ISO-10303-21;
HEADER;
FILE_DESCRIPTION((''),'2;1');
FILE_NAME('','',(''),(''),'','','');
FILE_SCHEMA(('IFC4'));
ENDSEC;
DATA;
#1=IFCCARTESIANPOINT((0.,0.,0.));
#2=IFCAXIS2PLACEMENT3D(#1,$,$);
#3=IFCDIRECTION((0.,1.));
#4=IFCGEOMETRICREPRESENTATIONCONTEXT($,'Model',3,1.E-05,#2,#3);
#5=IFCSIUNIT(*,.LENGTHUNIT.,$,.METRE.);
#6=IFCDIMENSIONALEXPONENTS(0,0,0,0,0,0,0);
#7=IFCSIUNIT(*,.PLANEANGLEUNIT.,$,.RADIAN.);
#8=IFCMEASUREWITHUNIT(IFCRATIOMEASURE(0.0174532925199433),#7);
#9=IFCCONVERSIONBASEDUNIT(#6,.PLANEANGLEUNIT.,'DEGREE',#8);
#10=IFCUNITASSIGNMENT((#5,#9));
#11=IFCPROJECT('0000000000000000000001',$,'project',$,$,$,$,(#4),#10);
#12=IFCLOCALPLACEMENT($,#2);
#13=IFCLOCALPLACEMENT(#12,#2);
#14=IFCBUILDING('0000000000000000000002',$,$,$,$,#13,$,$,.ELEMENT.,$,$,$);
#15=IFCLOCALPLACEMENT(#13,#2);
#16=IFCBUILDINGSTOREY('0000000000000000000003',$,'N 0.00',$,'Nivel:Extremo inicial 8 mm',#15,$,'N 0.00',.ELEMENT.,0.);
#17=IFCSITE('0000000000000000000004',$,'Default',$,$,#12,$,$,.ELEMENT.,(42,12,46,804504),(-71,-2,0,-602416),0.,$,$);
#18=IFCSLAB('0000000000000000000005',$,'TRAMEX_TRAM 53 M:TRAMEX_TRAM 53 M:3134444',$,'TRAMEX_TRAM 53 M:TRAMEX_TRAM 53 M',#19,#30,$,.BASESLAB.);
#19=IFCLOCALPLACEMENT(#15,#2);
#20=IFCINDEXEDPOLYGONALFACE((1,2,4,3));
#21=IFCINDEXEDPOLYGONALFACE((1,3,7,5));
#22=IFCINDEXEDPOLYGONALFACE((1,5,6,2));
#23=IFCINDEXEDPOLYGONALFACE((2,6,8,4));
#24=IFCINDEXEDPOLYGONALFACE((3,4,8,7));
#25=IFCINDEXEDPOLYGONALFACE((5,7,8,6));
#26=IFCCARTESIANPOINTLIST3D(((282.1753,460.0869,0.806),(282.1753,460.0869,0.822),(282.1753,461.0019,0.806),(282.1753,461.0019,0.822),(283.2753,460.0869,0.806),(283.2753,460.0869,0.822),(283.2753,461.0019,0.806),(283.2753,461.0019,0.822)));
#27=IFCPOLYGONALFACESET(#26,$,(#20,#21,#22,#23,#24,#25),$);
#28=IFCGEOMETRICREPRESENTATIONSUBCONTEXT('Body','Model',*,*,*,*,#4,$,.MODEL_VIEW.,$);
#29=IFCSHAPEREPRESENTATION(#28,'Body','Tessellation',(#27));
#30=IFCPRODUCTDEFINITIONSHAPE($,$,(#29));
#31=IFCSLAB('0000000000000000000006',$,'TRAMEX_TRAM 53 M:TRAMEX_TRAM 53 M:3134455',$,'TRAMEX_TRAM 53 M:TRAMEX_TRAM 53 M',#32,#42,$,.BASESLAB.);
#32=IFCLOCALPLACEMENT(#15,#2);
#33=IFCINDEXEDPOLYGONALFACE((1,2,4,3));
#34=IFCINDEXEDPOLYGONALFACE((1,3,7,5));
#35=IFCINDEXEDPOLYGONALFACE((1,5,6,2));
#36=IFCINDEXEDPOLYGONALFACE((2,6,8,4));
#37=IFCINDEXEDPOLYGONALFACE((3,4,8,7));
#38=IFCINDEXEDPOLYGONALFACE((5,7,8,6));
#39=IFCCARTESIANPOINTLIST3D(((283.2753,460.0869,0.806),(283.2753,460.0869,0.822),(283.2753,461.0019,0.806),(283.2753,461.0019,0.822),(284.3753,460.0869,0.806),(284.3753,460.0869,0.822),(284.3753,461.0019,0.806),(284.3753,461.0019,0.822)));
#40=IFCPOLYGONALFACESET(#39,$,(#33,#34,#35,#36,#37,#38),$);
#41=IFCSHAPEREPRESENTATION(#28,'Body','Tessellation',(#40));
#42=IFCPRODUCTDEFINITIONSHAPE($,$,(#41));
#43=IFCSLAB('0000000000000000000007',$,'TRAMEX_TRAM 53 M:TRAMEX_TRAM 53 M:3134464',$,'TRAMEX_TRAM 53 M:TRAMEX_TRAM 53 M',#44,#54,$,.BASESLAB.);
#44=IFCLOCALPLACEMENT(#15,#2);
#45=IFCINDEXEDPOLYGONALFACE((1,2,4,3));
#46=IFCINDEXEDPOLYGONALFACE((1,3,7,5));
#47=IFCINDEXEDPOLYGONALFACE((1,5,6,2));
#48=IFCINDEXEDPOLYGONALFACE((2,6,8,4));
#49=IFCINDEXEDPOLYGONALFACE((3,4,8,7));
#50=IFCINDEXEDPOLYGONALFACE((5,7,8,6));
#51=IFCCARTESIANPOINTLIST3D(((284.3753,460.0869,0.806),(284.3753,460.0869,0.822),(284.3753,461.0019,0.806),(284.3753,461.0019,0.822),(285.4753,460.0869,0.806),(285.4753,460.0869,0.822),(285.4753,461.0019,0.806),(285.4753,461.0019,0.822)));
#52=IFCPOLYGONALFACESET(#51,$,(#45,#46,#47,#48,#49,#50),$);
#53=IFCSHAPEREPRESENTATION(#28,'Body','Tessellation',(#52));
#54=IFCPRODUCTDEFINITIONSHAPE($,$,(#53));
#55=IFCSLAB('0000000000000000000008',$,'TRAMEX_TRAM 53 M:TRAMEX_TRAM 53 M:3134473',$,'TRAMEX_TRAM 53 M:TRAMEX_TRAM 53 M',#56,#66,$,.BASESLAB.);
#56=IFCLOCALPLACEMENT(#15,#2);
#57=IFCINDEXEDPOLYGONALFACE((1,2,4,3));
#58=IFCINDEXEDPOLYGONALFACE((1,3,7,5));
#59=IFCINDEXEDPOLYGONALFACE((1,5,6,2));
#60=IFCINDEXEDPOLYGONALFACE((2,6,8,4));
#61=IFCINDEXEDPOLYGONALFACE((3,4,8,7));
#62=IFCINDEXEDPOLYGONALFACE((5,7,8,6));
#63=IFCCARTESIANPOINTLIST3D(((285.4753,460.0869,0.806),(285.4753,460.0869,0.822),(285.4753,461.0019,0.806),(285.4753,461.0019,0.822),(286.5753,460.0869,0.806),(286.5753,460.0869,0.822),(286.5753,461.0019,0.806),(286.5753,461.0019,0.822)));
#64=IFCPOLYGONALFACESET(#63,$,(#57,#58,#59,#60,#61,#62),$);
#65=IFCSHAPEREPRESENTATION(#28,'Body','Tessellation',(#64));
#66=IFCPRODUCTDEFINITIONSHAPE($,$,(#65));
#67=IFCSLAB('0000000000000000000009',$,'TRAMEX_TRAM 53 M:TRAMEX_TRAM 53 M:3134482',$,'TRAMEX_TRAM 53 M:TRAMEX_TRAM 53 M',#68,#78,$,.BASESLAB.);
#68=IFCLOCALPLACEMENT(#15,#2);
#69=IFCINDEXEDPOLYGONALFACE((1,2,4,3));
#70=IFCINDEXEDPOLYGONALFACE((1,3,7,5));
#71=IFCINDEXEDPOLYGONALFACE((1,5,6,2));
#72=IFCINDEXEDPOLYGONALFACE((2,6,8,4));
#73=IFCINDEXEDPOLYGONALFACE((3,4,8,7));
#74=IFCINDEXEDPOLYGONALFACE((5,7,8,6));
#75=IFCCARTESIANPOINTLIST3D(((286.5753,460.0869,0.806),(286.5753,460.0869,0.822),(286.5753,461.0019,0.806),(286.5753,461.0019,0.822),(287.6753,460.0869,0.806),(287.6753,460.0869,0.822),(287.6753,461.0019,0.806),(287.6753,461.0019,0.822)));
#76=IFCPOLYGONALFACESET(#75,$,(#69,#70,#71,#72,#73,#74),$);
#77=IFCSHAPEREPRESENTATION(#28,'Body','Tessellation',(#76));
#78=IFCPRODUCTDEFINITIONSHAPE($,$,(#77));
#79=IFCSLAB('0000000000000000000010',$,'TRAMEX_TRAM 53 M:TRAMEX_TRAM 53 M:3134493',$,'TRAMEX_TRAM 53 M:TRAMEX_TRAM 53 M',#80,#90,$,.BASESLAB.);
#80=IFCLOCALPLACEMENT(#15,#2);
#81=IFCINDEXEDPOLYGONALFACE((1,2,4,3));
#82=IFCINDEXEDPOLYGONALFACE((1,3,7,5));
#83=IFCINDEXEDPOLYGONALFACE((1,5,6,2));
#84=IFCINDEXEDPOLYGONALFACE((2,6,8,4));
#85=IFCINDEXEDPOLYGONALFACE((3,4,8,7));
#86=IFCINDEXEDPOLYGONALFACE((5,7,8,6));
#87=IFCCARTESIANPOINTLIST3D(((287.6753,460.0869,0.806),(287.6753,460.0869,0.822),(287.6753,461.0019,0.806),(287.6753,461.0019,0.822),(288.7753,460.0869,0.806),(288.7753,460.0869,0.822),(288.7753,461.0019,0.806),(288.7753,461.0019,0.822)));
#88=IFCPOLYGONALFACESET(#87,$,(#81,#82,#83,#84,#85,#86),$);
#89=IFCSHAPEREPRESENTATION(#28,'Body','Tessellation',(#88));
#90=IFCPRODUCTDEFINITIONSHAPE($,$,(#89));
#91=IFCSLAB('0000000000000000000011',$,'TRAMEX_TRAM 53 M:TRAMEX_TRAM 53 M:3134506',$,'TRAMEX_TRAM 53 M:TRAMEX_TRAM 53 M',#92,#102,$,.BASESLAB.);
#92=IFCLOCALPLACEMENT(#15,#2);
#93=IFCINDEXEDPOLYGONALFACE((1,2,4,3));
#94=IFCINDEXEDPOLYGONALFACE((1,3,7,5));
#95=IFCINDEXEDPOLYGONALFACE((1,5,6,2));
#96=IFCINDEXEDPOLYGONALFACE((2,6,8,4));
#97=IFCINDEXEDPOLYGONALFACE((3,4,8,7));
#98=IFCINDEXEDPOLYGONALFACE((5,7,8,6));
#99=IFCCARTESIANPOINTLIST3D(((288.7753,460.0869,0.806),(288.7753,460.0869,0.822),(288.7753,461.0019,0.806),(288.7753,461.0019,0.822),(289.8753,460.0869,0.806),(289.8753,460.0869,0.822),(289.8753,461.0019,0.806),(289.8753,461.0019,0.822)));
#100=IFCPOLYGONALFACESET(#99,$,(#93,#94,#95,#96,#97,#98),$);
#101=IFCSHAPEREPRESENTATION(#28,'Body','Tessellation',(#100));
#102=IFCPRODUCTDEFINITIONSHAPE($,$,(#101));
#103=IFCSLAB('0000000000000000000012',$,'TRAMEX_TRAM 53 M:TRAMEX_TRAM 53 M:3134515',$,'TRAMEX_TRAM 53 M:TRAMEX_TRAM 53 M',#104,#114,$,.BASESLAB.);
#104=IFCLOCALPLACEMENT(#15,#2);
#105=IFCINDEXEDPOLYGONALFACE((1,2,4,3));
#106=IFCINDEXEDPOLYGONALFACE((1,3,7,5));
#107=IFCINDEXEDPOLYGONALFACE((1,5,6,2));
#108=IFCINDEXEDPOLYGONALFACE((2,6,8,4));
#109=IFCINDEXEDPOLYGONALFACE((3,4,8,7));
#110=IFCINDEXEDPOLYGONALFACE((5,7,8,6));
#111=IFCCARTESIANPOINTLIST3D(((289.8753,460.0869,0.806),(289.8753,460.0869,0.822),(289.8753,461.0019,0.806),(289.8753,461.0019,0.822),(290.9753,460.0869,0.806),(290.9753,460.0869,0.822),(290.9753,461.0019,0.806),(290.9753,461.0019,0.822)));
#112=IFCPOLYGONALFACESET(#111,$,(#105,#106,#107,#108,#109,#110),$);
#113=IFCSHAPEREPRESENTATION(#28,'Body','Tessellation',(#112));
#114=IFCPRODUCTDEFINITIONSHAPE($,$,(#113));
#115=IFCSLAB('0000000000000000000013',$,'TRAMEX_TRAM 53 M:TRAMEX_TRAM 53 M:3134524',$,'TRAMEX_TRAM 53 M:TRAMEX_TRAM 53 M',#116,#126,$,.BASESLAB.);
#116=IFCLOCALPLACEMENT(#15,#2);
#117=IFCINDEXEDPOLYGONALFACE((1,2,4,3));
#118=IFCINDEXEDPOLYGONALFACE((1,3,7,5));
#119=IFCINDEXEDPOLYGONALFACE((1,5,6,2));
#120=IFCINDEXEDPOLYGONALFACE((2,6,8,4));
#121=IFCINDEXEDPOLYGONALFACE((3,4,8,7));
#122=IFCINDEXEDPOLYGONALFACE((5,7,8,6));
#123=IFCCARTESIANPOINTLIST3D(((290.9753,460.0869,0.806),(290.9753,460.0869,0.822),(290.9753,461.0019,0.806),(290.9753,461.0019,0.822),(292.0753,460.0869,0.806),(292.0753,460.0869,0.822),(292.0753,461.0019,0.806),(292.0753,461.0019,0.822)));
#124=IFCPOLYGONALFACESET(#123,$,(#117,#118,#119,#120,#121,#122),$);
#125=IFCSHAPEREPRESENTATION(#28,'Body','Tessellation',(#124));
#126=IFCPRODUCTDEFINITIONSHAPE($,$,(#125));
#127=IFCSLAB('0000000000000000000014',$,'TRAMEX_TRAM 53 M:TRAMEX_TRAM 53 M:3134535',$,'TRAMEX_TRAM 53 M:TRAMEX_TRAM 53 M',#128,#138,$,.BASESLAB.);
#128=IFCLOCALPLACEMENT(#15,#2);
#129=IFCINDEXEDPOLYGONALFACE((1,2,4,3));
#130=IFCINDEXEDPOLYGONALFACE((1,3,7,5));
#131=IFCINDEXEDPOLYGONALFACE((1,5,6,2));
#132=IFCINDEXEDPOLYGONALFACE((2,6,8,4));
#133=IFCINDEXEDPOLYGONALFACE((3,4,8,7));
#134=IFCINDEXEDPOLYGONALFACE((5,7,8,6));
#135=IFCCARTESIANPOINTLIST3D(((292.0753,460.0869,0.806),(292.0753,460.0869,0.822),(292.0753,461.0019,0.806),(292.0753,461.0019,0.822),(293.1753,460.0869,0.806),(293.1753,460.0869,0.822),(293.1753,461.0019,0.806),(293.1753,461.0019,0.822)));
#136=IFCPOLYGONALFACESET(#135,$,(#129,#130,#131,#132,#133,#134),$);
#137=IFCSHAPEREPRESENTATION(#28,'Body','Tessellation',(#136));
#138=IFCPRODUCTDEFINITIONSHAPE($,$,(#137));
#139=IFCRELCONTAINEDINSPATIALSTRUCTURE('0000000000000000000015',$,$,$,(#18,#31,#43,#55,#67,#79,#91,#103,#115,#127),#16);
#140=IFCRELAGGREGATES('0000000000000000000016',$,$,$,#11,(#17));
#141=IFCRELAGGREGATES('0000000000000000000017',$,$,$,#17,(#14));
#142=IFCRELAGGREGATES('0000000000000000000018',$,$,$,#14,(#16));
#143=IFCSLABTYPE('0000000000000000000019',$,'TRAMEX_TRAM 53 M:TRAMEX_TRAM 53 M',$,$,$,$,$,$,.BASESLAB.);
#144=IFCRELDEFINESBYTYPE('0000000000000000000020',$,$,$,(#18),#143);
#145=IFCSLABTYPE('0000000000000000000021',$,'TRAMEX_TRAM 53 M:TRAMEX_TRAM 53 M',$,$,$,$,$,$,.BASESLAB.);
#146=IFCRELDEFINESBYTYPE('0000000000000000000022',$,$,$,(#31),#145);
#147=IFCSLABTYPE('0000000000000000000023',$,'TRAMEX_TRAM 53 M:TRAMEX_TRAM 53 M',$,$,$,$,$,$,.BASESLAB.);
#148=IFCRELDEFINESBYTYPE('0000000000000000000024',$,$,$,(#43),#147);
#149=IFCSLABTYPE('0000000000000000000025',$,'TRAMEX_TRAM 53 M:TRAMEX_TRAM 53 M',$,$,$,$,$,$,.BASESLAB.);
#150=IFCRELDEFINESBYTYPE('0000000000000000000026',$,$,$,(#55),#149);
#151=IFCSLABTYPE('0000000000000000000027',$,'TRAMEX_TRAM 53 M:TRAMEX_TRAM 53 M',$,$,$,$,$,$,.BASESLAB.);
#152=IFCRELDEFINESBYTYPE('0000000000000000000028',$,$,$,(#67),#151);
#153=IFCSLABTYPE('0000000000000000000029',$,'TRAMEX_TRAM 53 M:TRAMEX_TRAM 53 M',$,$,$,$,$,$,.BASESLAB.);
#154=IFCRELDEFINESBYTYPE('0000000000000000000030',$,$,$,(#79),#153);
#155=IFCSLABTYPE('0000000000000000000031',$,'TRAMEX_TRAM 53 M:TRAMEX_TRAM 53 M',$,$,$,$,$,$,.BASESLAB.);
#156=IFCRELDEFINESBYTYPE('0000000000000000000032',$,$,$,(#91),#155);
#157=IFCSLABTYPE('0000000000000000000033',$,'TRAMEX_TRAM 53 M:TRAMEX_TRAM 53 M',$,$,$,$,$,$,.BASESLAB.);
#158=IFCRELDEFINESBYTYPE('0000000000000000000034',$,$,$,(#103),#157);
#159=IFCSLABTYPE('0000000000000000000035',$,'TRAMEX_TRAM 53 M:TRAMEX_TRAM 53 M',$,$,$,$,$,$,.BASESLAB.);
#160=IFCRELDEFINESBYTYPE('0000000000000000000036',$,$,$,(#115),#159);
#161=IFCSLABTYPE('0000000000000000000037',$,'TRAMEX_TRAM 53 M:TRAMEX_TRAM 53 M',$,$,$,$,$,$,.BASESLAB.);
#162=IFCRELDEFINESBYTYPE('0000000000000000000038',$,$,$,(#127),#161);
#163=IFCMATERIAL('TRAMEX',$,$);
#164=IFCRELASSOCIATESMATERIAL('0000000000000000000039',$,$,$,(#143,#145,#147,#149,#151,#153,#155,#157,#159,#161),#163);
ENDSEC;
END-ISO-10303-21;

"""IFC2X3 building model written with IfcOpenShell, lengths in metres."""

from ifc_helpers import new_model, entity, si_unit, converted_unit, direction, frame, frame_2d, origin, place, context, subcontext, project, spatial, rectangle, extrude, material, type_object, element, save


model = new_model("IFC2X3")

# Units and contexts
model_context = context("Model", 3, precision=1e-05, world=origin(), true_north=direction((0.0, 1.0)))
body_context = subcontext(model_context, "Body", "Model", "MODEL_VIEW")
ifc_project = project(units=[si_unit("LENGTHUNIT", "METRE"), converted_unit("PLANEANGLEUNIT", "DEGREE", entity("IfcRatioMeasure", 0.0174532925199433), si_unit("PLANEANGLEUNIT", "RADIAN"), dimensions=[0, 0, 0, 0, 0, 0, 0])], contexts=[model_context])

# Site, building, storey
site_placement = place(None, origin())
site = spatial("IfcSite", under=ifc_project, at=site_placement, Name="Default", CompositionType="ELEMENT", RefLatitude=(42, 12, 46, 804504), RefLongitude=(-71, -2, 0, -602416), RefElevation=0.0)
building_placement = place(site_placement, origin())
building = spatial("IfcBuilding", under=site, at=building_placement, CompositionType="ELEMENT")
storey_placement = place(building_placement, origin())
storey = spatial("IfcBuildingStorey", under=building, at=storey_placement, Name="N 0.00", ObjectType="Nivel:Extremo inicial 8 mm", LongName="N 0.00", CompositionType="ELEMENT", Elevation=0.0)

# Slabs
ifc_material_1 = material(Name="TRAMEX")
slab_type_1 = type_object("IfcSlabType", Name="TRAMEX_TRAM 53 M:TRAMEX_TRAM 53 M", PredefinedType="BASESLAB", material=ifc_material_1)
slab_1_placement = place(storey_placement, origin())
element("IfcSlab", 1, at=slab_1_placement, inside=storey, type_object=slab_type_1, Name="TRAMEX_TRAM 53 M:TRAMEX_TRAM 53 M:3134444", ObjectType="TRAMEX_TRAM 53 M:TRAMEX_TRAM 53 M", PredefinedType="BASESLAB", context=body_context, shape_type="SweptSolid", body=[
    extrude(rectangle(XDim=0.915, YDim=1.1, at=frame_2d((0.0, 0.0), x_axis=(1.0, 0.0))), frame((282.7253, 460.5444, 0.806), z_axis=(0.0, 0.0, 1.0), x_axis=(0.0, 1.0, 0.0)), (0.0, 0.0, 1.0), 0.016),
])
slab_type_2 = type_object("IfcSlabType", Name="TRAMEX_TRAM 53 M:TRAMEX_TRAM 53 M", PredefinedType="BASESLAB", material=ifc_material_1)
slab_2_placement = place(storey_placement, origin())
element("IfcSlab", 2, at=slab_2_placement, inside=storey, type_object=slab_type_2, Name="TRAMEX_TRAM 53 M:TRAMEX_TRAM 53 M:3134455", ObjectType="TRAMEX_TRAM 53 M:TRAMEX_TRAM 53 M", PredefinedType="BASESLAB", context=body_context, shape_type="SweptSolid", body=[
    extrude(rectangle(XDim=0.915, YDim=1.1, at=frame_2d((0.0, 0.0), x_axis=(1.0, 0.0))), frame((283.8253, 460.5444, 0.806), z_axis=(0.0, 0.0, 1.0), x_axis=(0.0, 1.0, 0.0)), (0.0, 0.0, 1.0), 0.016),
])
slab_type_3 = type_object("IfcSlabType", Name="TRAMEX_TRAM 53 M:TRAMEX_TRAM 53 M", PredefinedType="BASESLAB", material=ifc_material_1)
slab_3_placement = place(storey_placement, origin())
element("IfcSlab", 3, at=slab_3_placement, inside=storey, type_object=slab_type_3, Name="TRAMEX_TRAM 53 M:TRAMEX_TRAM 53 M:3134464", ObjectType="TRAMEX_TRAM 53 M:TRAMEX_TRAM 53 M", PredefinedType="BASESLAB", context=body_context, shape_type="SweptSolid", body=[
    extrude(rectangle(XDim=0.915, YDim=1.1, at=frame_2d((0.0, 0.0), x_axis=(1.0, 0.0))), frame((284.9253, 460.5444, 0.806), z_axis=(0.0, 0.0, 1.0), x_axis=(0.0, 1.0, 0.0)), (0.0, 0.0, 1.0), 0.016),
])
slab_type_4 = type_object("IfcSlabType", Name="TRAMEX_TRAM 53 M:TRAMEX_TRAM 53 M", PredefinedType="BASESLAB", material=ifc_material_1)
slab_4_placement = place(storey_placement, origin())
element("IfcSlab", 4, at=slab_4_placement, inside=storey, type_object=slab_type_4, Name="TRAMEX_TRAM 53 M:TRAMEX_TRAM 53 M:3134473", ObjectType="TRAMEX_TRAM 53 M:TRAMEX_TRAM 53 M", PredefinedType="BASESLAB", context=body_context, shape_type="SweptSolid", body=[
    extrude(rectangle(XDim=0.915, YDim=1.1, at=frame_2d((0.0, 0.0), x_axis=(1.0, 0.0))), frame((286.0253, 460.5444, 0.806), z_axis=(0.0, 0.0, 1.0), x_axis=(0.0, 1.0, 0.0)), (0.0, 0.0, 1.0), 0.016),
])
slab_type_5 = type_object("IfcSlabType", Name="TRAMEX_TRAM 53 M:TRAMEX_TRAM 53 M", PredefinedType="BASESLAB", material=ifc_material_1)
slab_5_placement = place(storey_placement, origin())
element("IfcSlab", 5, at=slab_5_placement, inside=storey, type_object=slab_type_5, Name="TRAMEX_TRAM 53 M:TRAMEX_TRAM 53 M:3134482", ObjectType="TRAMEX_TRAM 53 M:TRAMEX_TRAM 53 M", PredefinedType="BASESLAB", context=body_context, shape_type="SweptSolid", body=[
    extrude(rectangle(XDim=0.915, YDim=1.1, at=frame_2d((0.0, 0.0), x_axis=(1.0, 0.0))), frame((287.1253, 460.5444, 0.806), z_axis=(0.0, 0.0, 1.0), x_axis=(0.0, 1.0, 0.0)), (0.0, 0.0, 1.0), 0.016),
])
slab_type_6 = type_object("IfcSlabType", Name="TRAMEX_TRAM 53 M:TRAMEX_TRAM 53 M", PredefinedType="BASESLAB", material=ifc_material_1)
slab_6_placement = place(storey_placement, origin())
element("IfcSlab", 6, at=slab_6_placement, inside=storey, type_object=slab_type_6, Name="TRAMEX_TRAM 53 M:TRAMEX_TRAM 53 M:3134493", ObjectType="TRAMEX_TRAM 53 M:TRAMEX_TRAM 53 M", PredefinedType="BASESLAB", context=body_context, shape_type="SweptSolid", body=[
    extrude(rectangle(XDim=0.915, YDim=1.1, at=frame_2d((0.0, 0.0), x_axis=(1.0, 0.0))), frame((288.2253, 460.5444, 0.806), z_axis=(0.0, 0.0, 1.0), x_axis=(0.0, 1.0, 0.0)), (0.0, 0.0, 1.0), 0.016),
])
slab_type_7 = type_object("IfcSlabType", Name="TRAMEX_TRAM 53 M:TRAMEX_TRAM 53 M", PredefinedType="BASESLAB", material=ifc_material_1)
slab_7_placement = place(storey_placement, origin())
element("IfcSlab", 7, at=slab_7_placement, inside=storey, type_object=slab_type_7, Name="TRAMEX_TRAM 53 M:TRAMEX_TRAM 53 M:3134506", ObjectType="TRAMEX_TRAM 53 M:TRAMEX_TRAM 53 M", PredefinedType="BASESLAB", context=body_context, shape_type="SweptSolid", body=[
    extrude(rectangle(XDim=0.915, YDim=1.1, at=frame_2d((0.0, 0.0), x_axis=(1.0, 0.0))), frame((289.3253, 460.5444, 0.806), z_axis=(0.0, 0.0, 1.0), x_axis=(0.0, 1.0, 0.0)), (0.0, 0.0, 1.0), 0.016),
])
slab_type_8 = type_object("IfcSlabType", Name="TRAMEX_TRAM 53 M:TRAMEX_TRAM 53 M", PredefinedType="BASESLAB", material=ifc_material_1)
slab_8_placement = place(storey_placement, origin())
element("IfcSlab", 8, at=slab_8_placement, inside=storey, type_object=slab_type_8, Name="TRAMEX_TRAM 53 M:TRAMEX_TRAM 53 M:3134515", ObjectType="TRAMEX_TRAM 53 M:TRAMEX_TRAM 53 M", PredefinedType="BASESLAB", context=body_context, shape_type="SweptSolid", body=[
    extrude(rectangle(XDim=0.915, YDim=1.1, at=frame_2d((0.0, 0.0), x_axis=(1.0, 0.0))), frame((290.4253, 460.5444, 0.806), z_axis=(0.0, 0.0, 1.0), x_axis=(0.0, 1.0, 0.0)), (0.0, 0.0, 1.0), 0.016),
])
slab_type_9 = type_object("IfcSlabType", Name="TRAMEX_TRAM 53 M:TRAMEX_TRAM 53 M", PredefinedType="BASESLAB", material=ifc_material_1)
slab_9_placement = place(storey_placement, origin())
element("IfcSlab", 9, at=slab_9_placement, inside=storey, type_object=slab_type_9, Name="TRAMEX_TRAM 53 M:TRAMEX_TRAM 53 M:3134524", ObjectType="TRAMEX_TRAM 53 M:TRAMEX_TRAM 53 M", PredefinedType="BASESLAB", context=body_context, shape_type="SweptSolid", body=[
    extrude(rectangle(XDim=0.915, YDim=1.1, at=frame_2d((0.0, 0.0), x_axis=(1.0, 0.0))), frame((291.5253, 460.5444, 0.806), z_axis=(0.0, 0.0, 1.0), x_axis=(0.0, 1.0, 0.0)), (0.0, 0.0, 1.0), 0.016),
])
slab_type_10 = type_object("IfcSlabType", Name="TRAMEX_TRAM 53 M:TRAMEX_TRAM 53 M", PredefinedType="BASESLAB", material=ifc_material_1)
slab_10_placement = place(storey_placement, origin())
element("IfcSlab", 10, at=slab_10_placement, inside=storey, type_object=slab_type_10, Name="TRAMEX_TRAM 53 M:TRAMEX_TRAM 53 M:3134535", ObjectType="TRAMEX_TRAM 53 M:TRAMEX_TRAM 53 M", PredefinedType="BASESLAB", context=body_context, shape_type="SweptSolid", body=[
    extrude(rectangle(XDim=0.915, YDim=1.1, at=frame_2d((0.0, 0.0), x_axis=(1.0, 0.0))), frame((292.6253, 460.5444, 0.806), z_axis=(0.0, 0.0, 1.0), x_axis=(0.0, 1.0, 0.0)), (0.0, 0.0, 1.0), 0.016),
])

save(model, "model.ifc")
